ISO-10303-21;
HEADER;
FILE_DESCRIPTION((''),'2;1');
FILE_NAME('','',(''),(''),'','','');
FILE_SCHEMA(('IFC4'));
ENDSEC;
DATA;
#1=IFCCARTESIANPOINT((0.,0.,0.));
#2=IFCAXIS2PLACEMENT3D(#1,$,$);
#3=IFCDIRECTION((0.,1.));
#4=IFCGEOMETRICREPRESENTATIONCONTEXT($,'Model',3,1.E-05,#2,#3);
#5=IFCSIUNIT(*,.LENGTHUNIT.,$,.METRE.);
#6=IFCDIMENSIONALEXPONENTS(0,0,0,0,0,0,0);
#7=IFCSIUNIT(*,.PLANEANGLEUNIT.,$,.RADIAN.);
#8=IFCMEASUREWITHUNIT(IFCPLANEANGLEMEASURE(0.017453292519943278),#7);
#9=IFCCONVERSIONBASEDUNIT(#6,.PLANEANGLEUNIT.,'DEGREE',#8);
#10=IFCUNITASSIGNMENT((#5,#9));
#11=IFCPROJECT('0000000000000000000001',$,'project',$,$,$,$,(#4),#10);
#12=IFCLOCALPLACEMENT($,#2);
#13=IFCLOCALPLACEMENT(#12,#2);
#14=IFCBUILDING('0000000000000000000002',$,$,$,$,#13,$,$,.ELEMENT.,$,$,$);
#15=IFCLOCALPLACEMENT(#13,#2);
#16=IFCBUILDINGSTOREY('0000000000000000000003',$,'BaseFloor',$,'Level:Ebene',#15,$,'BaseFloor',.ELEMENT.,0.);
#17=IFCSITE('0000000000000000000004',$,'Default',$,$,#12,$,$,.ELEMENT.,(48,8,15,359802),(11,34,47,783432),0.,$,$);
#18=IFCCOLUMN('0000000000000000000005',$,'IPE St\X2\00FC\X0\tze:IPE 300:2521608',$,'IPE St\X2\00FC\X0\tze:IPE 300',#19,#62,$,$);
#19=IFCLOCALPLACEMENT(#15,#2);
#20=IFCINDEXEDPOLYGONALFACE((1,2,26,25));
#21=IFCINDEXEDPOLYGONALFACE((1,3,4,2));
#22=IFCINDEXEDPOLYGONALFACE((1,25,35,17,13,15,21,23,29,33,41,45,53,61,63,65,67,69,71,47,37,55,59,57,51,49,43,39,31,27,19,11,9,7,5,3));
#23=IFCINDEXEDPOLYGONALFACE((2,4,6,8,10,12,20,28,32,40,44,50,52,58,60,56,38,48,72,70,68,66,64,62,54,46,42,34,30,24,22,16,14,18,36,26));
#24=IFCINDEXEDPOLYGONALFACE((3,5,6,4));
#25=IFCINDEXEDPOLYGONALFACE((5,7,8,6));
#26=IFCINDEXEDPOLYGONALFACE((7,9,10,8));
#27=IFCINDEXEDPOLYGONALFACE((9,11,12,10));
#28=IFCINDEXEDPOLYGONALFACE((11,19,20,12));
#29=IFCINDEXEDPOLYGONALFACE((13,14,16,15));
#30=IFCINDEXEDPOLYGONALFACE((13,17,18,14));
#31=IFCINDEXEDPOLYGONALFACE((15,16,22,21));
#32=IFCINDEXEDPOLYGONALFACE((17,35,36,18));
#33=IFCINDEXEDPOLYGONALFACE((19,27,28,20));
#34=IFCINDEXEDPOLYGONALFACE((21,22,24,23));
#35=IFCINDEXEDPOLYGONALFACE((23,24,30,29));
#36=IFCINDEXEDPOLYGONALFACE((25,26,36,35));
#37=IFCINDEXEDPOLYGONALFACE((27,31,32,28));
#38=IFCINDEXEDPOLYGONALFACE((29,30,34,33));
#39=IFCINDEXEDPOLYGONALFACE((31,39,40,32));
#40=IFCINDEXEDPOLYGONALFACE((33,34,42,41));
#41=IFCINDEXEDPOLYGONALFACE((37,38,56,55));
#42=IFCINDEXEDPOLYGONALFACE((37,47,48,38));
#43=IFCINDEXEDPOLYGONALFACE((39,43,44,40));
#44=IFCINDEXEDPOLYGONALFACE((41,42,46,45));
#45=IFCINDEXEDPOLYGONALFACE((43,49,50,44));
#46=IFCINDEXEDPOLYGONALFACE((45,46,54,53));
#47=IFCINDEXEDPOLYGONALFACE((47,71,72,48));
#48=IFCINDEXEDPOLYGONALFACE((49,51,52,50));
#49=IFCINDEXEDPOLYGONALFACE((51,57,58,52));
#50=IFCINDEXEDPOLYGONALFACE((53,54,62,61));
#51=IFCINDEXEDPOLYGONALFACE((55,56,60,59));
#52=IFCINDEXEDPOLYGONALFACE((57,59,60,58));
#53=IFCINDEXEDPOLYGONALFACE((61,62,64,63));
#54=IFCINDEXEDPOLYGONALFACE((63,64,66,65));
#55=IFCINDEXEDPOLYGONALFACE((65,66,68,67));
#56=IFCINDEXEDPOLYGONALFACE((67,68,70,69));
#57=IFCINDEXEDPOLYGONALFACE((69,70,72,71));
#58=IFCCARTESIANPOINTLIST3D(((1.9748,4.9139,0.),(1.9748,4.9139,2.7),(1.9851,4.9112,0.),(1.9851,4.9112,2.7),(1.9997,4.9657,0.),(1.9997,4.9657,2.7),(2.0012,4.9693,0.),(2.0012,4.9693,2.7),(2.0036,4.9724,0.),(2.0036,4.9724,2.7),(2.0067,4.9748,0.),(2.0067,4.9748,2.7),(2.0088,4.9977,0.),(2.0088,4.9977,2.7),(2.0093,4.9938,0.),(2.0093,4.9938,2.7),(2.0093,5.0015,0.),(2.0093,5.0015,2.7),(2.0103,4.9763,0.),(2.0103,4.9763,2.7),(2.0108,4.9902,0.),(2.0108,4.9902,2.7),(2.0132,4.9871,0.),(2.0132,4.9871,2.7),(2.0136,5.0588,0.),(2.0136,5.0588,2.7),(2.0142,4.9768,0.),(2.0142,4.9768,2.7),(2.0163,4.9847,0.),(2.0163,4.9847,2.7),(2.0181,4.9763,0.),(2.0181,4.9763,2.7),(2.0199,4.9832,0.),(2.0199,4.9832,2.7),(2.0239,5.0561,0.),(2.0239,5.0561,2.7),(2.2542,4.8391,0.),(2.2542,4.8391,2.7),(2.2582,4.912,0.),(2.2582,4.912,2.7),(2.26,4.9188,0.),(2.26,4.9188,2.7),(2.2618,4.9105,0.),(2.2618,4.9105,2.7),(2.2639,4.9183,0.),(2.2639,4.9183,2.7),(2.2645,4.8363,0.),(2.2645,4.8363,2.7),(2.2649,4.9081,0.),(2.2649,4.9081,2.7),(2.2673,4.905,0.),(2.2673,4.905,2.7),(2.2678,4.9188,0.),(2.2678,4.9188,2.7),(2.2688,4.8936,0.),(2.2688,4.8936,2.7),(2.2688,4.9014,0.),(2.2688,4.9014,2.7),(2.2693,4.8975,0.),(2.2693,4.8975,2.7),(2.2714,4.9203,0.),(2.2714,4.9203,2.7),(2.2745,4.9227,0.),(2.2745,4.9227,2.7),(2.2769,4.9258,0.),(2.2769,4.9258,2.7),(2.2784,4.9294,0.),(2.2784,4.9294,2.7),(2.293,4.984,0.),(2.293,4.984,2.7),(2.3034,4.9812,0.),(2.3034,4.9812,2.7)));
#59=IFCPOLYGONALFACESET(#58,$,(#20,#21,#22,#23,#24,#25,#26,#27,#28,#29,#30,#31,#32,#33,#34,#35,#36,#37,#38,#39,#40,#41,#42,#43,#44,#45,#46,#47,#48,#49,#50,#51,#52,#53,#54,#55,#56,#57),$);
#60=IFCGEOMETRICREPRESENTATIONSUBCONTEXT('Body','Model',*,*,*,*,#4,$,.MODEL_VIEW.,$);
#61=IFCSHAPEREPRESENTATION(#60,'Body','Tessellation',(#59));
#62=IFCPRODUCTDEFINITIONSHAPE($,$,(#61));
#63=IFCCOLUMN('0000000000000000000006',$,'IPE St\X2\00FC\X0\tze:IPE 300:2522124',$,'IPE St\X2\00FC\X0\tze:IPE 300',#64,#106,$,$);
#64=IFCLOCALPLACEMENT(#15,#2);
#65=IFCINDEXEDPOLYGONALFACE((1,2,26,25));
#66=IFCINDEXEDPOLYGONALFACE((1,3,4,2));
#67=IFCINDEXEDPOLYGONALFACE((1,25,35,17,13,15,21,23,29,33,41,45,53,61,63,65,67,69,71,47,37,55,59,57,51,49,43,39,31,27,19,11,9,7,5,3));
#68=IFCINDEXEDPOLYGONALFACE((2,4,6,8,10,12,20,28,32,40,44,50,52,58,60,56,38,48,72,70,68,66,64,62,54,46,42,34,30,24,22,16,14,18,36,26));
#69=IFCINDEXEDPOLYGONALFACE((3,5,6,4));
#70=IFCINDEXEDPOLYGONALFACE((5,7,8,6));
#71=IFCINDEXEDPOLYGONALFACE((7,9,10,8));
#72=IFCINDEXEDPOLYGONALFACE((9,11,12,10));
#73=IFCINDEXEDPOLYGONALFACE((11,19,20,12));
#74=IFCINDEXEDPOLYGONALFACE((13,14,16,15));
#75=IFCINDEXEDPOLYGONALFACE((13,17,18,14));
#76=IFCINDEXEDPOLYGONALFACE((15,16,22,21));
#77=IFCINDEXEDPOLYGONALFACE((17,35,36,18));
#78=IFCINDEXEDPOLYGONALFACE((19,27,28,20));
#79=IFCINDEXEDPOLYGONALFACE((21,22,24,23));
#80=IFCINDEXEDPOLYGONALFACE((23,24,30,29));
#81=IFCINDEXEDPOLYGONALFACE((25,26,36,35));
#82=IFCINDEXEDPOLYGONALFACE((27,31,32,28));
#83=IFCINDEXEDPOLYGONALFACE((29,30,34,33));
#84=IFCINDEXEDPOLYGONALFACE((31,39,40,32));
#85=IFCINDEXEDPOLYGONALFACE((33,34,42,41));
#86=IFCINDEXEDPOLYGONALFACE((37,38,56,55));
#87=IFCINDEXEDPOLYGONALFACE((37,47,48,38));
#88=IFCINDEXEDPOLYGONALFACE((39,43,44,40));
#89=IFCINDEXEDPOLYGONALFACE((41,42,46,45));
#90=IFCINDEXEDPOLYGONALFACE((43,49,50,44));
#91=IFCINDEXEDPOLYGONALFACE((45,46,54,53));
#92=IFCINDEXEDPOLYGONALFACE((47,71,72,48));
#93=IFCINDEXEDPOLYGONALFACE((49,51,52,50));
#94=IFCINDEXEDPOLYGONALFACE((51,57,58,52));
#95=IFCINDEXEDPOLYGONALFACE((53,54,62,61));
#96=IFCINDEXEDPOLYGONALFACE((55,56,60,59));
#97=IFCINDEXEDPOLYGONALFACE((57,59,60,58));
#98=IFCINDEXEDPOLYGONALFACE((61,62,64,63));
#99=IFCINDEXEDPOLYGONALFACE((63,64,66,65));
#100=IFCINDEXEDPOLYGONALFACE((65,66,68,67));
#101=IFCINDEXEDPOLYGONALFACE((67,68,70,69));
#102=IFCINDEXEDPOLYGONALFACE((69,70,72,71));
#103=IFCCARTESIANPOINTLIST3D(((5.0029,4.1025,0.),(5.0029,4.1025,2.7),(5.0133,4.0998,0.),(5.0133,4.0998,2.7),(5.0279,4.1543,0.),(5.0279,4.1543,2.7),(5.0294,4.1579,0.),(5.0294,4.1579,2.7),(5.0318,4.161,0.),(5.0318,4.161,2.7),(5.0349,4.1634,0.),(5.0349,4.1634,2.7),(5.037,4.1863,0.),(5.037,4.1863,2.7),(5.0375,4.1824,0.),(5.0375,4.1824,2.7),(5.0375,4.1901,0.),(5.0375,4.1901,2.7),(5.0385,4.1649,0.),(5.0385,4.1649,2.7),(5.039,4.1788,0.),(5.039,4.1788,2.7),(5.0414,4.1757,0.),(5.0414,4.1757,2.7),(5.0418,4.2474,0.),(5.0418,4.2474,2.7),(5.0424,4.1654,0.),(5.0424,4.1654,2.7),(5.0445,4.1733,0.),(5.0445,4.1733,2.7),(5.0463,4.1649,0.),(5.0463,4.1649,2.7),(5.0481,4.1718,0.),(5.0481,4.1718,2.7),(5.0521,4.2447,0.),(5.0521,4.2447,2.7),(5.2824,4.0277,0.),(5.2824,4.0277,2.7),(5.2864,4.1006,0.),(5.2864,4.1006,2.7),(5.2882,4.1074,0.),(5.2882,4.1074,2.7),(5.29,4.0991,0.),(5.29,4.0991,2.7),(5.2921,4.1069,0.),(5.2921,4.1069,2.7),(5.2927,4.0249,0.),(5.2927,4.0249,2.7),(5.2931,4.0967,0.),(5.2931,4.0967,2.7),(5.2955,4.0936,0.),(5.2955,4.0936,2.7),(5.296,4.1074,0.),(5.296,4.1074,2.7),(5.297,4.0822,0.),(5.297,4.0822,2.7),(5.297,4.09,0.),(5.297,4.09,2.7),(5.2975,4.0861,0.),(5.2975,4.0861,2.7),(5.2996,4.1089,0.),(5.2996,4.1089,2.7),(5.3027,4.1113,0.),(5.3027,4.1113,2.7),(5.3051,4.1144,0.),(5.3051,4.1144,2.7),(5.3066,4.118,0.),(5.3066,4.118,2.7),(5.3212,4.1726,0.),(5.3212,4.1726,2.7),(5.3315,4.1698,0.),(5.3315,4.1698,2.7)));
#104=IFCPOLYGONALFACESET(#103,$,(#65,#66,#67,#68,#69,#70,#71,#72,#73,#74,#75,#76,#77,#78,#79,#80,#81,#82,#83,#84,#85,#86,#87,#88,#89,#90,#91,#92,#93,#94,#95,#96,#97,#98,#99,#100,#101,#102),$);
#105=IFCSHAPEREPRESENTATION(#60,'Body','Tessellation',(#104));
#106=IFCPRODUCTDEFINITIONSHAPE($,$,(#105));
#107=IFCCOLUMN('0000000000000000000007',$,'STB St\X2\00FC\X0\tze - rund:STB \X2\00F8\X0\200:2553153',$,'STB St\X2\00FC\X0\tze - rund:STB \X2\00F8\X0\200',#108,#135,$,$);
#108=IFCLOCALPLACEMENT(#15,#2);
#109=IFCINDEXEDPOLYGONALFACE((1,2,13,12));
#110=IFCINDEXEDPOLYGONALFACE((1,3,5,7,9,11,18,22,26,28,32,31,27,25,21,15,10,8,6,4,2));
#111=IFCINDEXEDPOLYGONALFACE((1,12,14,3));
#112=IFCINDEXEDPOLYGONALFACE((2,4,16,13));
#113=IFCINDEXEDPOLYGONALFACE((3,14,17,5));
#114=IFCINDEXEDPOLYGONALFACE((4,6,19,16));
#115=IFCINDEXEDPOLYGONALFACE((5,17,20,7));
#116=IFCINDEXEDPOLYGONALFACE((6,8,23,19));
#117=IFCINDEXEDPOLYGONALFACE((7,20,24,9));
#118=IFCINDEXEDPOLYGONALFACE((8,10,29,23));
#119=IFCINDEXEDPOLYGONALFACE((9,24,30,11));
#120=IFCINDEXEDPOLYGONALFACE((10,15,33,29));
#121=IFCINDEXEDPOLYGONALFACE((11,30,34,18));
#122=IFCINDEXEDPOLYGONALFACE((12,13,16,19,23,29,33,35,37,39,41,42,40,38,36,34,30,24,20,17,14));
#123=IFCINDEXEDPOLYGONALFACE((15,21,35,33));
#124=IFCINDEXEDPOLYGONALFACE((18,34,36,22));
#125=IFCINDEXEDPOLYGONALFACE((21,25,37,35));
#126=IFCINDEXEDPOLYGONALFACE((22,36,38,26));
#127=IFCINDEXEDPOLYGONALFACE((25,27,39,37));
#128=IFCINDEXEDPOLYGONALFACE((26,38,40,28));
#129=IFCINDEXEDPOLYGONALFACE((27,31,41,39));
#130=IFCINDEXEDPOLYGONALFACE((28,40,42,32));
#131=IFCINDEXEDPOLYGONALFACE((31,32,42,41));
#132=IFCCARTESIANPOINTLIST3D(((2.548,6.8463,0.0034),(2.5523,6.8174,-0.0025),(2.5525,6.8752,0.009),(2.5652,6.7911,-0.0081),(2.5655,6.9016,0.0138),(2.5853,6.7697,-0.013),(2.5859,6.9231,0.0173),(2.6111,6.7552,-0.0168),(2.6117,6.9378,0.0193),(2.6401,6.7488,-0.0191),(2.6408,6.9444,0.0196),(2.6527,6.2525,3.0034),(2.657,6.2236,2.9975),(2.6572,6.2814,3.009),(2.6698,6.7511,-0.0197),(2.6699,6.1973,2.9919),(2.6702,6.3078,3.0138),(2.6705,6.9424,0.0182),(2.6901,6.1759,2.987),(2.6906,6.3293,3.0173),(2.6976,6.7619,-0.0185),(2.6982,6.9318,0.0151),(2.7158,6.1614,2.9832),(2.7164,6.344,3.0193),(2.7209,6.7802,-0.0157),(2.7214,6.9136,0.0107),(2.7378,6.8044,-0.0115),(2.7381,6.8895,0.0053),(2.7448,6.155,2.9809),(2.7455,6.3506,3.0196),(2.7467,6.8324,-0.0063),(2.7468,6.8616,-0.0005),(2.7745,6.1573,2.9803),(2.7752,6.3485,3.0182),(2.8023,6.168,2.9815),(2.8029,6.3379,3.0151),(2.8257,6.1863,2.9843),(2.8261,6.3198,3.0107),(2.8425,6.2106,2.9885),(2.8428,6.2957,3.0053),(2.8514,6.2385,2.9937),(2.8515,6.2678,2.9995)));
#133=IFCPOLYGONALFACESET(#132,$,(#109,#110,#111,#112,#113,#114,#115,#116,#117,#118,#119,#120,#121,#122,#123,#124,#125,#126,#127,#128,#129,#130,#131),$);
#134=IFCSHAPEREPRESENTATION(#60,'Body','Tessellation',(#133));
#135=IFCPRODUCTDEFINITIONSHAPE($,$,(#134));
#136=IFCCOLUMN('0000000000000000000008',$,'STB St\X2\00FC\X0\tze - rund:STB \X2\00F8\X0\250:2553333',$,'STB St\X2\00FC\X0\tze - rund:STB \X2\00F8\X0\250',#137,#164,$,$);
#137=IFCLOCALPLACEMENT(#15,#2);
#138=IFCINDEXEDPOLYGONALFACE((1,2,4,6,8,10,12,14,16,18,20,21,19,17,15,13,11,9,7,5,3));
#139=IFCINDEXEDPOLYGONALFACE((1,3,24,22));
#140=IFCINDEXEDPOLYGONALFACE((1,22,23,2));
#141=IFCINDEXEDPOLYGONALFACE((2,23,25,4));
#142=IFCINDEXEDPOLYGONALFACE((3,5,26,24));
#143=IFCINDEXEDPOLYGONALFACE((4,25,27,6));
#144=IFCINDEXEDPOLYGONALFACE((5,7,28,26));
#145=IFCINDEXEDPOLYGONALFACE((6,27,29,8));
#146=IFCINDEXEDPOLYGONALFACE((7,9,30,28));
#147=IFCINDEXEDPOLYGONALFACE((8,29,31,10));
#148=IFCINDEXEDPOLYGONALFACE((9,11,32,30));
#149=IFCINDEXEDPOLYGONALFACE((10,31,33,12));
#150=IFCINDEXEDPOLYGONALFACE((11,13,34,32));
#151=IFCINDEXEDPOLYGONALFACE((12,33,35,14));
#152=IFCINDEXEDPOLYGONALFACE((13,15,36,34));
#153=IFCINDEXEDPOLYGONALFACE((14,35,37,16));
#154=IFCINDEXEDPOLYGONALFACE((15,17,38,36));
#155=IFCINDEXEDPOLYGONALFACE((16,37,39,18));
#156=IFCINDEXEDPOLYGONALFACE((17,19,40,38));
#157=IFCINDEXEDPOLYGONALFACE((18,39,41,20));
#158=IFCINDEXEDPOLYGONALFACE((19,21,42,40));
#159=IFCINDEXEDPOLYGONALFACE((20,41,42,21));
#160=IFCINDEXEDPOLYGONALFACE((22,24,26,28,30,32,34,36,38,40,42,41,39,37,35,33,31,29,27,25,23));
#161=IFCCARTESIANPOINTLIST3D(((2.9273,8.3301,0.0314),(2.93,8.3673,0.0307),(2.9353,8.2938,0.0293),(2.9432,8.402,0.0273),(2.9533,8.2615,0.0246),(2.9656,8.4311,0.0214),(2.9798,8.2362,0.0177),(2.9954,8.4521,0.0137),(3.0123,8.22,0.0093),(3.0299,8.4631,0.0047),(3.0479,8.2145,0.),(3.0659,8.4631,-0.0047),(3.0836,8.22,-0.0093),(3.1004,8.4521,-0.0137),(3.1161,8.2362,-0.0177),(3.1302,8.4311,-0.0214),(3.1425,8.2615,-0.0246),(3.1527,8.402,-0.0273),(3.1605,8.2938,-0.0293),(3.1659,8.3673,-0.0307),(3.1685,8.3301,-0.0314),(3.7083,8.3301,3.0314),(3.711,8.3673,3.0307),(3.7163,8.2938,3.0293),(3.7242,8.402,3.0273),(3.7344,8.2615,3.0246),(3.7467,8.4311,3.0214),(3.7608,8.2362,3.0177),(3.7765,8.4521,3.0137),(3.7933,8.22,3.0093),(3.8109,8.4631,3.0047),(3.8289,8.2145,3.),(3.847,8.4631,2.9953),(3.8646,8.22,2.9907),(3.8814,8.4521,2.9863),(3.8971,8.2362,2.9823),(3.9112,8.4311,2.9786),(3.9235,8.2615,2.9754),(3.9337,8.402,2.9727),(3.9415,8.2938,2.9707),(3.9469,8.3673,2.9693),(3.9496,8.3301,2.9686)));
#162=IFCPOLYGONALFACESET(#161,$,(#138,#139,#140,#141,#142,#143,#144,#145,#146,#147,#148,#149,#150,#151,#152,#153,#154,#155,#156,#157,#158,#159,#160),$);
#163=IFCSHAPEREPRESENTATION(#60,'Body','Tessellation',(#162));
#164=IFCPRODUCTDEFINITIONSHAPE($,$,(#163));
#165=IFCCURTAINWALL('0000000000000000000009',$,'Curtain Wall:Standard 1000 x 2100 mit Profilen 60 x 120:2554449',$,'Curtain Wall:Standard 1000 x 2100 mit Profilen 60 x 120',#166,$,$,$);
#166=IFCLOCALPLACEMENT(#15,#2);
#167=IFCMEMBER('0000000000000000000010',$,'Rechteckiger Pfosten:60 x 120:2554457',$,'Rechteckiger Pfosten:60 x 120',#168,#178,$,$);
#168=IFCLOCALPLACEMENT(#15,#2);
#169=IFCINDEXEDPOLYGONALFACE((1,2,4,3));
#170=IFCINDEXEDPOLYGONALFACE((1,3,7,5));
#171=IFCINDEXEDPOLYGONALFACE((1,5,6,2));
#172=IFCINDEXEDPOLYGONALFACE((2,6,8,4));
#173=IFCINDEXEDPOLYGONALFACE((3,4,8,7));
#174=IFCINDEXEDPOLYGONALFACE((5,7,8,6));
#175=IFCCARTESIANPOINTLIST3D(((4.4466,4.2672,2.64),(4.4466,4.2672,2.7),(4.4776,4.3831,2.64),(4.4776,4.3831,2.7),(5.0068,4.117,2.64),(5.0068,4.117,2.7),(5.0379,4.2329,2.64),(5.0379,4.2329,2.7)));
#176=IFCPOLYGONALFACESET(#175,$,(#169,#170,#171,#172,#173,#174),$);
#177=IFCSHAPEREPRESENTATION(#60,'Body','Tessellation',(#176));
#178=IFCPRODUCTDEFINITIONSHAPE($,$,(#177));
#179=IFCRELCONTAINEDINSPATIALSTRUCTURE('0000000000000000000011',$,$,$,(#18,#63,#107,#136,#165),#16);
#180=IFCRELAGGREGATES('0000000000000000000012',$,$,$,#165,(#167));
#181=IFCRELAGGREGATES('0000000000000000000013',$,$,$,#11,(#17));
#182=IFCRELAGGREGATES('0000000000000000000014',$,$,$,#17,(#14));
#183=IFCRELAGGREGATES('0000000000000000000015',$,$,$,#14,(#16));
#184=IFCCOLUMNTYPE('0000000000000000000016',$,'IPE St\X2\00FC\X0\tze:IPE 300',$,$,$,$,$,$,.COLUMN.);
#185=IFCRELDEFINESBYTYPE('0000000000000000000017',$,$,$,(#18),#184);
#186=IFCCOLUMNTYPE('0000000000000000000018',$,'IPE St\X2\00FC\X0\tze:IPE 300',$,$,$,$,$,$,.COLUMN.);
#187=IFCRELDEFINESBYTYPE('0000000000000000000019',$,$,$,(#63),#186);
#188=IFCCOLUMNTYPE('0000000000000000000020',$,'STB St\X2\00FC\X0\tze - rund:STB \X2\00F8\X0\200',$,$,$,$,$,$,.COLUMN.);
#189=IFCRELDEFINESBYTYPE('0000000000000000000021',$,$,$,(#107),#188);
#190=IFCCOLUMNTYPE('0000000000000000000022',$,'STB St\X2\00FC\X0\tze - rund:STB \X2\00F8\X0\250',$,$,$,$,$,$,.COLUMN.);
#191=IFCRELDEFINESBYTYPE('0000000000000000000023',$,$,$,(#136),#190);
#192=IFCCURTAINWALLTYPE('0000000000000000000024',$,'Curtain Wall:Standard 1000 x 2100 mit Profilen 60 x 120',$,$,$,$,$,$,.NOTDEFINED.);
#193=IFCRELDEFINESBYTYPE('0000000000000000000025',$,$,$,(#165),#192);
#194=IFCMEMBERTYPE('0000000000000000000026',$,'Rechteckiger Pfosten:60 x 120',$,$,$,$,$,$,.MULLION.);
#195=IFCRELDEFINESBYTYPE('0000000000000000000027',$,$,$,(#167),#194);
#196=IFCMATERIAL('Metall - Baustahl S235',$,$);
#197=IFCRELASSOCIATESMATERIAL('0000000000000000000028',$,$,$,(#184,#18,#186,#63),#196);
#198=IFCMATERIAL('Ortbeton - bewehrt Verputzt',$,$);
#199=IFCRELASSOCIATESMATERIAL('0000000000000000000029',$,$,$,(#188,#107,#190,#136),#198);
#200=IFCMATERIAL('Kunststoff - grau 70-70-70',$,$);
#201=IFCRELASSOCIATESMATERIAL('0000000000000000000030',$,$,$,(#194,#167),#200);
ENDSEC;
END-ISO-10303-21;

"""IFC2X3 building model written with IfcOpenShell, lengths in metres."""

from ifc_helpers import new_model, entity, si_unit, converted_unit, direction, frame, frame_2d, origin, origin_2d_with_axis, place, context, subcontext, project, spatial, rectangle, circle, i_section, extrude, source, transform, mapped, material, type_object, type_shapes, element, aggregate, save


model = new_model("IFC2X3")

# Units and contexts
model_context = context("Model", 3, precision=1e-05, world=origin(), true_north=direction((0.0, 1.0)))
body_context = subcontext(model_context, "Body", "Model", "MODEL_VIEW")
ifc_project = project(units=[si_unit("LENGTHUNIT", "METRE"), converted_unit("PLANEANGLEUNIT", "DEGREE", entity("IfcPlaneAngleMeasure", 0.017453292519943278), si_unit("PLANEANGLEUNIT", "RADIAN"), dimensions=[0, 0, 0, 0, 0, 0, 0])], contexts=[model_context])

# Site, building, storey
site_placement = place(None, origin())
site = spatial("IfcSite", under=ifc_project, at=site_placement, Name="Default", CompositionType="ELEMENT", RefLatitude=(48, 8, 15, 359802), RefLongitude=(11, 34, 47, 783432), RefElevation=0.0)
building_placement = place(site_placement, origin())
building = spatial("IfcBuilding", under=site, at=building_placement, CompositionType="ELEMENT")
storey_placement = place(building_placement, origin())
storey = spatial("IfcBuildingStorey", under=building, at=storey_placement, Name="BaseFloor", ObjectType="Level:Ebene", LongName="BaseFloor", CompositionType="ELEMENT", Elevation=0.0)

# Columns
ifc_material_1 = material(Name="Metall - Baustahl S235")
column_type_1 = type_object("IfcColumnType", Name="IPE Stütze:IPE 300", PredefinedType="COLUMN", material=ifc_material_1)
shared_shape_1 = source(origin(), body_context, "Body", "SweptSolid", [
    extrude(i_section(OverallWidth=0.15, OverallDepth=0.3, WebThickness=0.0071, FlangeThickness=0.0107, FilletRadius=0.015, at=origin_2d_with_axis()), frame((2.1391, 4.9476, 0.0), z_axis=(0.0, 0.0, 1.0), x_axis=(-0.258819, -0.965926, 0.0)), (0.0, 0.0, 1.0), 2.7),
])
type_shapes(column_type_1, [shared_shape_1])
column_1_placement = place(storey_placement, origin())
element("IfcColumn", 1, at=column_1_placement, inside=storey, type_object=column_type_1, material=ifc_material_1, Name="IPE Stütze:IPE 300:2521608", ObjectType="IPE Stütze:IPE 300", context=body_context, shape_type="MappedRepresentation", body=[
    mapped(shared_shape_1, transform((0.0, 0.0, 0.0), scale=1.0)),
])
column_type_2 = type_object("IfcColumnType", Name="IPE Stütze:IPE 300", PredefinedType="COLUMN", material=ifc_material_1)
shared_shape_2 = source(origin(), body_context, "Body", "SweptSolid", [
    extrude(i_section(OverallWidth=0.15, OverallDepth=0.3, WebThickness=0.0071, FlangeThickness=0.0107, FilletRadius=0.015, at=frame_2d((0.0, 0.0), x_axis=(1.0, 0.0))), frame((5.1672, 4.1362, 0.0), z_axis=(0.0, 0.0, 1.0), x_axis=(-0.258819, -0.965926, 0.0)), (0.0, 0.0, 1.0), 2.7),
])
type_shapes(column_type_2, [shared_shape_2])
column_2_placement = place(storey_placement, origin())
element("IfcColumn", 2, at=column_2_placement, inside=storey, type_object=column_type_2, material=ifc_material_1, Name="IPE Stütze:IPE 300:2522124", ObjectType="IPE Stütze:IPE 300", context=body_context, shape_type="MappedRepresentation", body=[
    mapped(shared_shape_2, transform((0.0, 0.0, 0.0), scale=1.0)),
])
ifc_material_2 = material(Name="Ortbeton - bewehrt Verputzt")
column_type_3 = type_object("IfcColumnType", Name="STB Stütze - rund:STB ø200", PredefinedType="COLUMN", material=ifc_material_2)
shared_shape_3 = source(origin(), body_context, "Body", "SweptSolid", [
    extrude(circle(Radius=0.1, at=frame_2d((0.0, 0.0), x_axis=(1.0, 0.0))), frame((2.6479, 6.8466, 0.0), z_axis=(0.034218, -0.194063, 0.980392), x_axis=(-0.999409, -0.003353, 0.034218)), (0.0, 0.0, 1.0), 3.06),
])
type_shapes(column_type_3, [shared_shape_3])
column_3_placement = place(storey_placement, origin())
element("IfcColumn", 3, at=column_3_placement, inside=storey, type_object=column_type_3, material=ifc_material_2, Name="STB Stütze - rund:STB ø200:2553153", ObjectType="STB Stütze - rund:STB ø200", context=body_context, shape_type="MappedRepresentation", body=[
    mapped(shared_shape_3, transform((0.0, 0.0, 0.0), scale=1.0)),
])
column_type_4 = type_object("IfcColumnType", Name="STB Stütze - rund:STB ø250", PredefinedType="COLUMN", material=ifc_material_2)
shared_shape_4 = source(origin(), body_context, "Body", "SweptSolid", [
    extrude(circle(Radius=0.125, at=frame_2d((0.0, 0.0), x_axis=(1.0, 0.0))), frame((3.0479, 8.3395, 0.0), z_axis=(0.251944, 0.0, 0.967742), x_axis=(0.0, -1.0, 0.0)), (0.0, 0.0, 1.0), 3.1),
])
type_shapes(column_type_4, [shared_shape_4])
column_4_placement = place(storey_placement, origin())
element("IfcColumn", 4, at=column_4_placement, inside=storey, type_object=column_type_4, material=ifc_material_2, Name="STB Stütze - rund:STB ø250:2553333", ObjectType="STB Stütze - rund:STB ø250", context=body_context, shape_type="MappedRepresentation", body=[
    mapped(shared_shape_4, transform((0.0, 0.0, 0.0), scale=1.0)),
])

# Curtain wall, member
curtain_wall_type = type_object("IfcCurtainWallType", Name="Curtain Wall:Standard 1000 x 2100 mit Profilen 60 x 120", PredefinedType="NOTDEFINED")
curtain_wall_placement = place(storey_placement, origin())
curtain_wall = element("IfcCurtainWall", 5, at=curtain_wall_placement, inside=storey, type_object=curtain_wall_type, Name="Curtain Wall:Standard 1000 x 2100 mit Profilen 60 x 120:2554449", ObjectType="Curtain Wall:Standard 1000 x 2100 mit Profilen 60 x 120")
ifc_material_3 = material(Name="Kunststoff - grau 70-70-70")
member_type_1 = type_object("IfcMemberType", Name="Rechteckiger Pfosten:60 x 120", PredefinedType="MULLION", material=ifc_material_3)
shared_shape_5 = source(origin(), body_context, "Body", "SweptSolid", [
    extrude(rectangle(XDim=0.06, YDim=0.12, at=origin_2d_with_axis()), frame((-0.03, 0.0, -0.58), z_axis=(0.0, 0.0, 1.0), x_axis=(-1.0, 0.0, 0.0)), (0.0, 0.0, 1.0), 0.58),
])
type_shapes(member_type_1, [shared_shape_5])
member_1_placement = place(curtain_wall_placement, frame((4.4621, 4.3251, 2.7), z_axis=(-0.965926, 0.258819, 0.0), x_axis=(0.0, 0.0, 1.0)))
member_1 = element("IfcMember", 6, at=member_1_placement, type_object=member_type_1, material=ifc_material_3, Name="Rechteckiger Pfosten:60 x 120:2554457", ObjectType="Rechteckiger Pfosten:60 x 120", context=body_context, shape_type="MappedRepresentation", body=[
    mapped(shared_shape_5, transform((0.0, 0.0, 0.0), scale=1.0)),
])

aggregate(curtain_wall, [member_1])

save(model, "model.ifc")
